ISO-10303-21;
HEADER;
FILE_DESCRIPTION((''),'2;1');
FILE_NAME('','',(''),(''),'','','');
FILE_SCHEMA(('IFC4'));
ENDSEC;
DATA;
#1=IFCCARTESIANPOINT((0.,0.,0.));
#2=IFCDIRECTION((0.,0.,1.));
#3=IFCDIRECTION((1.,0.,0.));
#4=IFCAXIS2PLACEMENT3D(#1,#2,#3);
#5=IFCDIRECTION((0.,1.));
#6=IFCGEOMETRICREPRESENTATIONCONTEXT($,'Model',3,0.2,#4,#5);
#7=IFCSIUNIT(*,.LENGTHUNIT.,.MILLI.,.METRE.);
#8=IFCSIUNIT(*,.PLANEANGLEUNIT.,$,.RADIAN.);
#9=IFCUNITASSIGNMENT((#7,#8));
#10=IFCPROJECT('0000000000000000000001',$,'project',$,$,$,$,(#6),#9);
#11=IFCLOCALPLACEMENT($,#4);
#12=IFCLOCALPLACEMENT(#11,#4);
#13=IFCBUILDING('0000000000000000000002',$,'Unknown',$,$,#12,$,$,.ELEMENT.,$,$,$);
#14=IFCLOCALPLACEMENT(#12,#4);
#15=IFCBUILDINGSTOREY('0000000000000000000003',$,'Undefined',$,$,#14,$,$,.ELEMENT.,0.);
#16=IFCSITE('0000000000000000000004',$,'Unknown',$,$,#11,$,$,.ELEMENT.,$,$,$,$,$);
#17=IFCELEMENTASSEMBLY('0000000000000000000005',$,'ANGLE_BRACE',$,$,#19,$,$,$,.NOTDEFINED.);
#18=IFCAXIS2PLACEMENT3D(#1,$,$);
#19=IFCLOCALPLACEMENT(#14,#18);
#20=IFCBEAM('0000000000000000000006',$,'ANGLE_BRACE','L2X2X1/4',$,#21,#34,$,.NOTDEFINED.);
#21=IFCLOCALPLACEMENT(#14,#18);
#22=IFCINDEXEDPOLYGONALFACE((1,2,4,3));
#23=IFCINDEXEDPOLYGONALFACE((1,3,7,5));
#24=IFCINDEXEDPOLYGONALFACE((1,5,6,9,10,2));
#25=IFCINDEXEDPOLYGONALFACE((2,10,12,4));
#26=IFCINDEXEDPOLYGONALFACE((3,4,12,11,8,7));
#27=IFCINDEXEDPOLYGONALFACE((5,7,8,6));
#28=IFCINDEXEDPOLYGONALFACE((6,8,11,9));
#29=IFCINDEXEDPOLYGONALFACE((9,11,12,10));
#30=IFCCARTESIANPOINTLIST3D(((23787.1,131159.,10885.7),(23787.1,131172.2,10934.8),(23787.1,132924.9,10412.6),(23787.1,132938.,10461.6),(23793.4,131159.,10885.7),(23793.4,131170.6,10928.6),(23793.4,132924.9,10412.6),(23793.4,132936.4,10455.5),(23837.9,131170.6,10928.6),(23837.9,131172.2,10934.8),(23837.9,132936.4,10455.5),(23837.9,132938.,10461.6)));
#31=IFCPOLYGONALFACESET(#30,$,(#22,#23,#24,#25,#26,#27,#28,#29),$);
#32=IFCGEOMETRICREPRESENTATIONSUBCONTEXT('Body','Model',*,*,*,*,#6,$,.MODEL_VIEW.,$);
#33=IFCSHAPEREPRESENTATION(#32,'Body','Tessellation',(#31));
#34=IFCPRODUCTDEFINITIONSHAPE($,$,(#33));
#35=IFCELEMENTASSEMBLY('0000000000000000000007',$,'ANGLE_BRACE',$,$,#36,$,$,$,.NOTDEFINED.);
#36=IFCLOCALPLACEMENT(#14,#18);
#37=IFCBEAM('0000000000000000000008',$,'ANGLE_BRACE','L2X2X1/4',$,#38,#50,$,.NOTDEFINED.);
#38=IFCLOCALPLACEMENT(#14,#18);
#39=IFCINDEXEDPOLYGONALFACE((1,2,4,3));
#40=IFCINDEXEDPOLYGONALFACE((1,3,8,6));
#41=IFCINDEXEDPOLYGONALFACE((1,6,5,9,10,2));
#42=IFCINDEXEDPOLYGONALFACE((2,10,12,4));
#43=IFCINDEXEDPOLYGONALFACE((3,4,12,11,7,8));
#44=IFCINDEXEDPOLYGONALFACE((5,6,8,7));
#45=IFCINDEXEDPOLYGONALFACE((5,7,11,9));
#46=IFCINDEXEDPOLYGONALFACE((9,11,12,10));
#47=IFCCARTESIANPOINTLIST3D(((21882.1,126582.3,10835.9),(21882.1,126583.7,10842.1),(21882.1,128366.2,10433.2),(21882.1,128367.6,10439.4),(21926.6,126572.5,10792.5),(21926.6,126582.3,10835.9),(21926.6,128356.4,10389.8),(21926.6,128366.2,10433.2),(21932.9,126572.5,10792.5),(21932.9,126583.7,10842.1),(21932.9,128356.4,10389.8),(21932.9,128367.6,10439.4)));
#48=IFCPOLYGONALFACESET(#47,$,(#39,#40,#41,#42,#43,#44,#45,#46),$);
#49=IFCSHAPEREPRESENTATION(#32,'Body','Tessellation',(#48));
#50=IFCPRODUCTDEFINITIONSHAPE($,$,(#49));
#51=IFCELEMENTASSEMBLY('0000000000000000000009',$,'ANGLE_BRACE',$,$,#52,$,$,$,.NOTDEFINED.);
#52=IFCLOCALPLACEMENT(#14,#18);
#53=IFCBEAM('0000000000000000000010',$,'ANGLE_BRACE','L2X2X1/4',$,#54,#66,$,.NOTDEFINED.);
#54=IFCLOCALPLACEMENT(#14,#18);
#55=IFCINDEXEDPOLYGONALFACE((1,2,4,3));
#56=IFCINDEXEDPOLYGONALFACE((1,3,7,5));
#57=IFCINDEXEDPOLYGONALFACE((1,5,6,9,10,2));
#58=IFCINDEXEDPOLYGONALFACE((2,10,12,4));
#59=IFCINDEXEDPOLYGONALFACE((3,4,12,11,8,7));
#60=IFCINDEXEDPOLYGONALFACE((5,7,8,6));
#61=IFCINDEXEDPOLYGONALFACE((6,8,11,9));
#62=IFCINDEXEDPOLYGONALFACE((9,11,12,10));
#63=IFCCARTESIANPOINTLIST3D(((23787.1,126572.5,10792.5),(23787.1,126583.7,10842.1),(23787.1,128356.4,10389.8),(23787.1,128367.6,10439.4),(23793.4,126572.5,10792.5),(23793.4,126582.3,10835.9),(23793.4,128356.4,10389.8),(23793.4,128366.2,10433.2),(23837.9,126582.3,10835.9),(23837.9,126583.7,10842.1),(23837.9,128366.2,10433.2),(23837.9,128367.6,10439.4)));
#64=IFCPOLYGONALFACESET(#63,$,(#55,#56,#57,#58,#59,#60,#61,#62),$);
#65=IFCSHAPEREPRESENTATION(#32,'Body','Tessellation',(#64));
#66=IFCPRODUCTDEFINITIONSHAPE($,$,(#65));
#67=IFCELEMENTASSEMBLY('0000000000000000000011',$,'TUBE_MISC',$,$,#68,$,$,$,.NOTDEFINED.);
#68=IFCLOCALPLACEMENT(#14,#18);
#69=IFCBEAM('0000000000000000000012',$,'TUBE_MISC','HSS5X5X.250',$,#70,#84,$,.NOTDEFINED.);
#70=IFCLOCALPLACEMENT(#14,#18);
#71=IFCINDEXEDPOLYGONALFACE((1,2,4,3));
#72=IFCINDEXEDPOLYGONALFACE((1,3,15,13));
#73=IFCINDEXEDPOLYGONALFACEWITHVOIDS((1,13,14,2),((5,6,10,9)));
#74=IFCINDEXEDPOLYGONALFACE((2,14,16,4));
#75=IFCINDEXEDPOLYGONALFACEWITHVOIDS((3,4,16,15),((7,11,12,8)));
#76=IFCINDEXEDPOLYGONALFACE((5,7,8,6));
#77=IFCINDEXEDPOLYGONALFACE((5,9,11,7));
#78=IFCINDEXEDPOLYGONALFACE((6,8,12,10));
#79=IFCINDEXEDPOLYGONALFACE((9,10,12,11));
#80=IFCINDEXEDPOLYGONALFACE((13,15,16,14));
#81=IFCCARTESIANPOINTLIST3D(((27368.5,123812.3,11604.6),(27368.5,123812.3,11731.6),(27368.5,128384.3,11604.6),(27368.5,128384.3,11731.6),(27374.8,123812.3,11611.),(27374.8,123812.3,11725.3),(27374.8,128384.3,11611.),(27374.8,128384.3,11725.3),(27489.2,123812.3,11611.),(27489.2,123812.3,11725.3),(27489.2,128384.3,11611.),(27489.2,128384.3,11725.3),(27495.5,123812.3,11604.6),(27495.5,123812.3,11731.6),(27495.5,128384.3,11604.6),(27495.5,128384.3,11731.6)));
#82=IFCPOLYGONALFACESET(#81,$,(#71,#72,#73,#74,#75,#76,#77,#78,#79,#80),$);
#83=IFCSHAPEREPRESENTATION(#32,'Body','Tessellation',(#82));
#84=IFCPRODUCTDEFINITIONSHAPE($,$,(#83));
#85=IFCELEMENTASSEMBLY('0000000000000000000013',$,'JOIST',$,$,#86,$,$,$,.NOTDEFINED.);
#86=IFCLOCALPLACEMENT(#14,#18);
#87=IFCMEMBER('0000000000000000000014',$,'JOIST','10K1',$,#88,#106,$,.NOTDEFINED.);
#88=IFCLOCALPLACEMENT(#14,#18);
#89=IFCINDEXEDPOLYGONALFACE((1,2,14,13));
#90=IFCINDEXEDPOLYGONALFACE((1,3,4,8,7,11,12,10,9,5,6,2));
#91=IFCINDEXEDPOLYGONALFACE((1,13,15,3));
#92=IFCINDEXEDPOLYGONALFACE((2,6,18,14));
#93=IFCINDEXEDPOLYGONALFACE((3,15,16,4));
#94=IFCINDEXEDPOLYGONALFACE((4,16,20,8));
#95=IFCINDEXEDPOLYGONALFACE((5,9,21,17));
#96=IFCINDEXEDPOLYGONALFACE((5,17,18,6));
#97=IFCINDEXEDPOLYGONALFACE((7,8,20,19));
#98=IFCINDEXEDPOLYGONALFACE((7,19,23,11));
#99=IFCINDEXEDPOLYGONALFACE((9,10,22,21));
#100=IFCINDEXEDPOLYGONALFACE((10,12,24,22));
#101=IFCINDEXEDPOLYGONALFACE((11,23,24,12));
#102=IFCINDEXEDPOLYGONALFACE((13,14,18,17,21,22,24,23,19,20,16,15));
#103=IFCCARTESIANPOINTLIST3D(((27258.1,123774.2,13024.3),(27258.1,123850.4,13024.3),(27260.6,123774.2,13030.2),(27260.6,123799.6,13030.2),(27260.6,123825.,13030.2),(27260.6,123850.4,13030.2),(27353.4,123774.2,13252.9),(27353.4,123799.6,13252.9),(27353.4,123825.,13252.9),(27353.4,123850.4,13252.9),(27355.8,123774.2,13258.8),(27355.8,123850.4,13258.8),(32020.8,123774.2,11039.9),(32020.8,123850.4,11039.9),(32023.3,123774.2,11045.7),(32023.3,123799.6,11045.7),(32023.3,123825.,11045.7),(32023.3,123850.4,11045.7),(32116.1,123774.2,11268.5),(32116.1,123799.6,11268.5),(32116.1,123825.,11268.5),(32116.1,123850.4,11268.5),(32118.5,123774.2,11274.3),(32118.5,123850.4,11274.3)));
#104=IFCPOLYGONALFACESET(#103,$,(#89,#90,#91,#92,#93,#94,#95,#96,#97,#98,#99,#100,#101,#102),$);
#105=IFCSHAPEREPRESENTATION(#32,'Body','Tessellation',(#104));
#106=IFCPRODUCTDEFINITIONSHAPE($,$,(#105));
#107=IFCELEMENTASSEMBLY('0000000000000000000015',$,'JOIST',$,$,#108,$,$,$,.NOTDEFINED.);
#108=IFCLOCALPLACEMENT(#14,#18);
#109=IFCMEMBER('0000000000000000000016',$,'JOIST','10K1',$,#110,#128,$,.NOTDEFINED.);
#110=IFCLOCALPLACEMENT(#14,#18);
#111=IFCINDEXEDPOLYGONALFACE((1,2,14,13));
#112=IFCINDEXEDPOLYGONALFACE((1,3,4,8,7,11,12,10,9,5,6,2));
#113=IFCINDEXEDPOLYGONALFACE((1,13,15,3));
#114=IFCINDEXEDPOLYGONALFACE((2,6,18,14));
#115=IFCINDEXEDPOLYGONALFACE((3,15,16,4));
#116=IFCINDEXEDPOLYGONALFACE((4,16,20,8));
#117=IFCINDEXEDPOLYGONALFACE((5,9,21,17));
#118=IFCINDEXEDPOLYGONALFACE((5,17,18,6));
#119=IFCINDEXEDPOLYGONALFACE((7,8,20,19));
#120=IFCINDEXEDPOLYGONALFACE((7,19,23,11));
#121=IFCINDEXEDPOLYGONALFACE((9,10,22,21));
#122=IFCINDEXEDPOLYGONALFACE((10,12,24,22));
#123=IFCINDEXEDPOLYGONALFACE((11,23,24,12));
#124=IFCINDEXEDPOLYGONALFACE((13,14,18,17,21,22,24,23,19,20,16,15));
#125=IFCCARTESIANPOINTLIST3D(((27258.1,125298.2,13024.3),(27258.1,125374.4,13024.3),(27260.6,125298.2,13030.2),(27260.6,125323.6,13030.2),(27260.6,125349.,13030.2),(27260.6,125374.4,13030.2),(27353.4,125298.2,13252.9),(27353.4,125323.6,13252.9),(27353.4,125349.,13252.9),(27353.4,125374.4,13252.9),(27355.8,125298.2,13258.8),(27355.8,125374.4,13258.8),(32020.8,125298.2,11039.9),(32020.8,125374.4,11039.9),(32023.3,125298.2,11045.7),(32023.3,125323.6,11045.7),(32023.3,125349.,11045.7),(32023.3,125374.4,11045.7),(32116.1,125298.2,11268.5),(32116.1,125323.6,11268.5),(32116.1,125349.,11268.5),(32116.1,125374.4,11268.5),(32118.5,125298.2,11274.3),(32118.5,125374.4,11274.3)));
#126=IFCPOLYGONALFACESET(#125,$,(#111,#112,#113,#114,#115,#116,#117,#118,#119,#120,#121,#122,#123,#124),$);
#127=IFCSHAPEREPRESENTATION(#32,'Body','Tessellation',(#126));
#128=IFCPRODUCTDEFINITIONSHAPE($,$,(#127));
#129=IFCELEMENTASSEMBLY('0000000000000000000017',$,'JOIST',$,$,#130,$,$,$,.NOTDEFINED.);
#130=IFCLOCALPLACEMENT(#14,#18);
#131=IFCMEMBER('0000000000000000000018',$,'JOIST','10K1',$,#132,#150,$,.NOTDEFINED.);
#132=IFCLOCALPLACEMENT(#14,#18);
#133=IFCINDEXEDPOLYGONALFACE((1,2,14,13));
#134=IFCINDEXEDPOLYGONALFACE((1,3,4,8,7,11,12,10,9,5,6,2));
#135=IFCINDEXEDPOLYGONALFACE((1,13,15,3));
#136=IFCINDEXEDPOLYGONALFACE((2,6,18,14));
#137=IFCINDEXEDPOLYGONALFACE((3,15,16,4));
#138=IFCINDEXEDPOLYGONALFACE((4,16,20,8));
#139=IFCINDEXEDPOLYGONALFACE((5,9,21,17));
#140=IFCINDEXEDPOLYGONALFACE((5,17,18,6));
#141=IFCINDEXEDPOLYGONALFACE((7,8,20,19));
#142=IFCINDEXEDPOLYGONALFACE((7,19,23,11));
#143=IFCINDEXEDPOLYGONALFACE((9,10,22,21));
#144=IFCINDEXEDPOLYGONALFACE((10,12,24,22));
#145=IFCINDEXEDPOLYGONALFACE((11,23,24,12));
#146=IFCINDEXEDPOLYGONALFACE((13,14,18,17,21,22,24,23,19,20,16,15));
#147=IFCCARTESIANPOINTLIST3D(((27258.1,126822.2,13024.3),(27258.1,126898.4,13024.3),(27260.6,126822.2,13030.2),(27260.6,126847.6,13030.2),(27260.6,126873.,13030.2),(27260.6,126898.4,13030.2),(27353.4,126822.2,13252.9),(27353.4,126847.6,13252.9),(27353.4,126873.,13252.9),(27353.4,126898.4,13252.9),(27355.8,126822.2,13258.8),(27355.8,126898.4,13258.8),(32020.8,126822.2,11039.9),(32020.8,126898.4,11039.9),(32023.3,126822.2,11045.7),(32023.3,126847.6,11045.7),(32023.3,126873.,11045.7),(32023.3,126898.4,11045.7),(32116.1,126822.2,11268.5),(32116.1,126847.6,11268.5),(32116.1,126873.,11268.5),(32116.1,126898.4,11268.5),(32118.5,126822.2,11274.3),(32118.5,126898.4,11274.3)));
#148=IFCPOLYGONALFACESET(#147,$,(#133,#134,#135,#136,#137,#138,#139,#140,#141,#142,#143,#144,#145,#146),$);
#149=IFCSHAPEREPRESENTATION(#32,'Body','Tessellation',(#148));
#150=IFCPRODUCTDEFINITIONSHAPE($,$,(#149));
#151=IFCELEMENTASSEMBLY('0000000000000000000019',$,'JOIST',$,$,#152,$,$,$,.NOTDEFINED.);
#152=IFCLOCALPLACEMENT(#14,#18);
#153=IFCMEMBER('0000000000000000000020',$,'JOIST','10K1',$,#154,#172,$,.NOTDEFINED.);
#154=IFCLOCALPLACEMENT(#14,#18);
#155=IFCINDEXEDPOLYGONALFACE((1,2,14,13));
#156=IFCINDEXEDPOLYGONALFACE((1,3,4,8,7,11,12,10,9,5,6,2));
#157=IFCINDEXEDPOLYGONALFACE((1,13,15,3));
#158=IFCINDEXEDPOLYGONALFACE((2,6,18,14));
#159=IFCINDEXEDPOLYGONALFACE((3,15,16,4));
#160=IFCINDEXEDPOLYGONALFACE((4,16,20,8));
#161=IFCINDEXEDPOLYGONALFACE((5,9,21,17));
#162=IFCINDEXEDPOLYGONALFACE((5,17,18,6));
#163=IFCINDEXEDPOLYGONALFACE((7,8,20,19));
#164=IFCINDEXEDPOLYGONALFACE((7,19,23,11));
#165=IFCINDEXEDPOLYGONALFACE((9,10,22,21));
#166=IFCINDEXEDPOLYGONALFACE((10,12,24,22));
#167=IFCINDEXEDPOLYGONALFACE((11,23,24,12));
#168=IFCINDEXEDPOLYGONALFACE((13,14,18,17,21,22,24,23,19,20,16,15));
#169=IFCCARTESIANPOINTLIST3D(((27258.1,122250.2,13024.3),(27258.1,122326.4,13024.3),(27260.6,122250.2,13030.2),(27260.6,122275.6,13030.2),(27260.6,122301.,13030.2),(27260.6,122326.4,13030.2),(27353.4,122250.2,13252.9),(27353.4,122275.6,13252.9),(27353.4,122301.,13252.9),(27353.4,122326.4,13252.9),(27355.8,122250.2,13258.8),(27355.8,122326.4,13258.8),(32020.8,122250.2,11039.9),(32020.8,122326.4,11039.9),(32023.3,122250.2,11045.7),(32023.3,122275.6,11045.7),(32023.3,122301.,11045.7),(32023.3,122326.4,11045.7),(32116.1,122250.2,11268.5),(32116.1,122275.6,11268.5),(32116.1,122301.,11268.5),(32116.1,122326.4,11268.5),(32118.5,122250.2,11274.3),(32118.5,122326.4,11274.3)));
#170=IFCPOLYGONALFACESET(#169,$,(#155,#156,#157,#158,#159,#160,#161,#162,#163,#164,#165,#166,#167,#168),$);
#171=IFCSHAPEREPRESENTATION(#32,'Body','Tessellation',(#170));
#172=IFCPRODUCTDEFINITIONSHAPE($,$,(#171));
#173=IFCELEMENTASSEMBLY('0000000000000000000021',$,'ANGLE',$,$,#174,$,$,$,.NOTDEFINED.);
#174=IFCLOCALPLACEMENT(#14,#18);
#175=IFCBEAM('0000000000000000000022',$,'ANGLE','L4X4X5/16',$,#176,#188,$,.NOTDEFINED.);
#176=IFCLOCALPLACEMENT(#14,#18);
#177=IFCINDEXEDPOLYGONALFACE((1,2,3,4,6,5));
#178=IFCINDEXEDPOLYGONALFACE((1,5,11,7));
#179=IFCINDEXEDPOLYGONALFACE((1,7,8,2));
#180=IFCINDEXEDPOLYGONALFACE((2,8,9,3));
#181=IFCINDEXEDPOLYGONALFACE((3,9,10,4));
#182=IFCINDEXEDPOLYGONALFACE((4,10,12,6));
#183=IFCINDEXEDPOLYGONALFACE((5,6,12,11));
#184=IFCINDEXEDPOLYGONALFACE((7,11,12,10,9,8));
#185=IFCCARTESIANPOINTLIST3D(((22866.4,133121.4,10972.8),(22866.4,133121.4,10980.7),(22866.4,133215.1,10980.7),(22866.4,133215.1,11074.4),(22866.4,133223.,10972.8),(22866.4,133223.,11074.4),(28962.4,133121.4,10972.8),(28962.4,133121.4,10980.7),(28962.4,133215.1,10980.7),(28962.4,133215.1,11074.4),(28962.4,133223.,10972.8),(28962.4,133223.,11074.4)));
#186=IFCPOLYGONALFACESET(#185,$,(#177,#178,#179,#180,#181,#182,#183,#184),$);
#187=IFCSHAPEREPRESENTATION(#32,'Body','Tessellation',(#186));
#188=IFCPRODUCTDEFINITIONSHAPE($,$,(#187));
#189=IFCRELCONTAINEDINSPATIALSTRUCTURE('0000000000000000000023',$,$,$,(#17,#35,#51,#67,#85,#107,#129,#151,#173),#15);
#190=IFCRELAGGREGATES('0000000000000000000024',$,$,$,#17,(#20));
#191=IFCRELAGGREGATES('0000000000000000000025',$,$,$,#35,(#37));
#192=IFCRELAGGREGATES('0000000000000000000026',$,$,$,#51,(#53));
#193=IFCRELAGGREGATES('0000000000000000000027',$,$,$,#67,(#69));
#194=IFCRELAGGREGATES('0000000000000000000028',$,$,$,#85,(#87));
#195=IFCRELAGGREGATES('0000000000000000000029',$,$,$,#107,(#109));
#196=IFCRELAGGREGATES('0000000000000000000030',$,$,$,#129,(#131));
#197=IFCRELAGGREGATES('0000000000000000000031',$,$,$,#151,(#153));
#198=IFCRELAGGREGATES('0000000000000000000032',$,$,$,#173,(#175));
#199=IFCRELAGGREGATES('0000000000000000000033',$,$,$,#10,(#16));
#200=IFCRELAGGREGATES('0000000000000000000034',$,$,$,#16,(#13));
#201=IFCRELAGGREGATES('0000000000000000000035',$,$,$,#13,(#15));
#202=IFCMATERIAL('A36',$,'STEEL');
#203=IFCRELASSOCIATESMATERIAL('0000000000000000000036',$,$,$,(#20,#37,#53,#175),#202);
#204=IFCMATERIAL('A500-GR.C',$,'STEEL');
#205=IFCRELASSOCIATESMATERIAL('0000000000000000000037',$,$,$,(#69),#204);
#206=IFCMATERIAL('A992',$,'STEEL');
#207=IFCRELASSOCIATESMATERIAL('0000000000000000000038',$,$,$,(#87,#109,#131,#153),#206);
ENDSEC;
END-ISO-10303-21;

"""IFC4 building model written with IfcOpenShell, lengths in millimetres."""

from ifc_helpers import new_model, si_unit, direction, frame, origin_with_axes, place, context, subcontext, project, spatial, line, indexed_curve, outline, extrude, material, element, aggregate, save


model = new_model("IFC4")

# Units and contexts
model_context = context("Model", 3, precision=0.2, world=origin_with_axes(), true_north=direction((0.0, 1.0)))
body_context = subcontext(model_context, "Body", "Model", "MODEL_VIEW")
ifc_project = project(units=[si_unit("LENGTHUNIT", "METRE", prefix="MILLI"), si_unit("PLANEANGLEUNIT", "RADIAN")], contexts=[model_context])

# Site, building, storey
site_placement = place(None, origin_with_axes())
site = spatial("IfcSite", under=ifc_project, at=site_placement, Name="Unknown", CompositionType="ELEMENT")
building_placement = place(site_placement, origin_with_axes())
building = spatial("IfcBuilding", under=site, at=building_placement, Name="Unknown", CompositionType="ELEMENT")
storey_placement = place(building_placement, origin_with_axes())
storey = spatial("IfcBuildingStorey", under=building, at=storey_placement, Name="Undefined", CompositionType="ELEMENT", Elevation=0.0)

# Shared definitions
ifc_material_1 = material(Name="A500-GR.C", Category="STEEL")

# Element assemblies, beams
ifc_material_2 = material(Name="A992", Category="STEEL")
ifc_material_3 = material(Name="A36", Category="STEEL")
assembly_1_placement = place(storey_placement, frame((23812.5, 131165.6, 10910.2), z_axis=(0.0, -0.258819, -0.965926), x_axis=(0.0, 0.965926, -0.258819)))
assembly_1 = element("IfcElementAssembly", 1, at=assembly_1_placement, inside=storey, Name="ANGLE_BRACE", PredefinedType="NOTDEFINED")
beam_1_placement = place(assembly_1_placement, origin_with_axes())
beam_1 = element("IfcBeam", 2, at=beam_1_placement, material=ifc_material_3, Name="ANGLE_BRACE", Description="L2X2X1/4", PredefinedType="NOTDEFINED", context=body_context, shape_type="SolidModel", body=[
    extrude(outline(indexed_curve([(-25.4, -25.4), (25.4, -25.4), (25.4, -19.1), (-19.1, -19.1), (-19.1, 25.4), (-25.4, 25.4)], segments=[line(1, 2, 3, 4, 5, 6, 1)])), frame((0.0, 0.0, 0.0), z_axis=(-1.0, 0.0, 0.0), x_axis=(0.0, 0.0, 1.0)), (0.0, 0.0, -1.0), 1828.1),
])
aggregate(assembly_1, [beam_1])
assembly_2_placement = place(storey_placement, frame((21907.5, 126578.1, 10817.3), z_axis=(-1.0, 0.0, 0.0), x_axis=(0.0, 0.97546, -0.220178)))
assembly_2 = element("IfcElementAssembly", 3, at=assembly_2_placement, inside=storey, Name="ANGLE_BRACE", PredefinedType="NOTDEFINED")
beam_2_placement = place(assembly_2_placement, origin_with_axes())
beam_2 = element("IfcBeam", 4, at=beam_2_placement, material=ifc_material_3, Name="ANGLE_BRACE", Description="L2X2X1/4", PredefinedType="NOTDEFINED", context=body_context, shape_type="SolidModel", body=[
    extrude(outline(indexed_curve([(-25.4, -25.4), (25.4, -25.4), (25.4, -19.1), (-19.1, -19.1), (-19.1, 25.4), (-25.4, 25.4)], segments=[line(1, 2, 3, 4, 5, 6, 1)])), frame((0.0, 0.0, 0.0), z_axis=(-1.0, 0.0, 0.0), x_axis=(0.0, 0.0, 1.0)), (0.0, 0.0, -1.0), 1828.8),
])
aggregate(assembly_2, [beam_2])
assembly_3_placement = place(storey_placement, frame((23812.5, 126578.1, 10817.3), z_axis=(0.0, -0.220178, -0.97546), x_axis=(0.0, 0.97546, -0.220178)))
assembly_3 = element("IfcElementAssembly", 5, at=assembly_3_placement, inside=storey, Name="ANGLE_BRACE", PredefinedType="NOTDEFINED")
beam_3_placement = place(assembly_3_placement, origin_with_axes())
beam_3 = element("IfcBeam", 6, at=beam_3_placement, material=ifc_material_3, Name="ANGLE_BRACE", Description="L2X2X1/4", PredefinedType="NOTDEFINED", context=body_context, shape_type="SolidModel", body=[
    extrude(outline(indexed_curve([(-25.4, -25.4), (25.4, -25.4), (25.4, -19.1), (-19.1, -19.1), (-19.1, 25.4), (-25.4, 25.4)], segments=[line(1, 2, 3, 4, 5, 6, 1)])), frame((0.0, 0.0, 0.0), z_axis=(-1.0, 0.0, 0.0), x_axis=(0.0, 0.0, 1.0)), (0.0, 0.0, -1.0), 1828.8),
])
aggregate(assembly_3, [beam_3])
assembly_4_placement = place(storey_placement, frame((27432.0, 123812.3, 11668.1), z_axis=(1.0, 0.0, 0.0), x_axis=(0.0, 1.0, 0.0)))
assembly_4 = element("IfcElementAssembly", 7, at=assembly_4_placement, inside=storey, Name="TUBE_MISC", PredefinedType="NOTDEFINED")
beam_4_placement = place(assembly_4_placement, origin_with_axes())
beam_4 = element("IfcBeam", 8, at=beam_4_placement, material=ifc_material_1, Name="TUBE_MISC", Description="HSS5X5X.250", PredefinedType="NOTDEFINED", context=body_context, shape_type="SolidModel", body=[
    extrude(outline(indexed_curve([(-63.5, -63.5), (63.5, -63.5), (63.5, 63.5), (-63.5, 63.5)], segments=[line(1, 2, 3, 4, 1)]), holes=[indexed_curve([(-57.1, -57.1), (-57.1, 57.1), (57.1, 57.1), (57.1, -57.1)], segments=[line(1, 2, 3, 4, 1)])]), frame((0.0, 0.0, 0.0), z_axis=(-1.0, 0.0, 0.0), x_axis=(0.0, 0.0, 1.0)), (0.0, 0.0, -1.0), 4572.0),
])
aggregate(assembly_4, [beam_4])

# Element assemblies, members
assembly_5_placement = place(storey_placement, frame((27307.0, 123812.3, 13141.6), z_axis=(0.0, -1.0, 0.0), x_axis=(0.923077, 0.000001, -0.384615)))
assembly_5 = element("IfcElementAssembly", 9, at=assembly_5_placement, inside=storey, Name="JOIST", PredefinedType="NOTDEFINED")
member_1_placement = place(assembly_5_placement, origin_with_axes())
member_1 = element("IfcMember", 10, at=member_1_placement, material=ifc_material_2, Name="JOIST", Description="10K1", PredefinedType="NOTDEFINED", context=body_context, shape_type="SolidModel", body=[
    extrude(outline(indexed_curve([(-38.1, -127.0), (38.1, -127.0), (38.1, -120.7), (12.7, -120.7), (12.7, 120.7), (38.1, 120.7), (38.1, 127.0), (-38.1, 127.0), (-38.1, 120.7), (-12.7, 120.7), (-12.7, -120.7), (-38.1, -120.7)], segments=[line(1, 2, 3, 4, 5, 6, 7, 8, 9, 10, 11, 12, 1)])), frame((0.0, 0.0, 0.0), z_axis=(-1.0, 0.0, 0.0), x_axis=(0.0, 0.0, 1.0)), (0.0, 0.0, -1.0), 5159.6),
])
aggregate(assembly_5, [member_1])
assembly_6_placement = place(storey_placement, frame((27307.0, 125336.3, 13141.6), z_axis=(0.0, -1.0, 0.0), x_axis=(0.923077, 0.000001, -0.384615)))
assembly_6 = element("IfcElementAssembly", 11, at=assembly_6_placement, inside=storey, Name="JOIST", PredefinedType="NOTDEFINED")
member_2_placement = place(assembly_6_placement, origin_with_axes())
member_2 = element("IfcMember", 12, at=member_2_placement, material=ifc_material_2, Name="JOIST", Description="10K1", PredefinedType="NOTDEFINED", context=body_context, shape_type="SolidModel", body=[
    extrude(outline(indexed_curve([(-38.1, -127.0), (38.1, -127.0), (38.1, -120.7), (12.7, -120.7), (12.7, 120.7), (38.1, 120.7), (38.1, 127.0), (-38.1, 127.0), (-38.1, 120.7), (-12.7, 120.7), (-12.7, -120.7), (-38.1, -120.7)], segments=[line(1, 2, 3, 4, 5, 6, 7, 8, 9, 10, 11, 12, 1)])), frame((0.0, 0.0, 0.0), z_axis=(-1.0, 0.0, 0.0), x_axis=(0.0, 0.0, 1.0)), (0.0, 0.0, -1.0), 5159.6),
])
aggregate(assembly_6, [member_2])
assembly_7_placement = place(storey_placement, frame((27307.0, 126860.3, 13141.6), z_axis=(0.0, -1.0, 0.0), x_axis=(0.923077, 0.000001, -0.384615)))
assembly_7 = element("IfcElementAssembly", 13, at=assembly_7_placement, inside=storey, Name="JOIST", PredefinedType="NOTDEFINED")
member_3_placement = place(assembly_7_placement, origin_with_axes())
member_3 = element("IfcMember", 14, at=member_3_placement, material=ifc_material_2, Name="JOIST", Description="10K1", PredefinedType="NOTDEFINED", context=body_context, shape_type="SolidModel", body=[
    extrude(outline(indexed_curve([(-38.1, -127.0), (38.1, -127.0), (38.1, -120.7), (12.7, -120.7), (12.7, 120.7), (38.1, 120.7), (38.1, 127.0), (-38.1, 127.0), (-38.1, 120.7), (-12.7, 120.7), (-12.7, -120.7), (-38.1, -120.7)], segments=[line(1, 2, 3, 4, 5, 6, 7, 8, 9, 10, 11, 12, 1)])), frame((0.0, 0.0, 0.0), z_axis=(-1.0, 0.0, 0.0), x_axis=(0.0, 0.0, 1.0)), (0.0, 0.0, -1.0), 5159.6),
])
aggregate(assembly_7, [member_3])
assembly_8_placement = place(storey_placement, frame((27307.0, 122288.3, 13141.6), z_axis=(0.0, -1.0, 0.0), x_axis=(0.923077, 0.000001, -0.384615)))
assembly_8 = element("IfcElementAssembly", 15, at=assembly_8_placement, inside=storey, Name="JOIST", PredefinedType="NOTDEFINED")
member_4_placement = place(assembly_8_placement, origin_with_axes())
member_4 = element("IfcMember", 16, at=member_4_placement, material=ifc_material_2, Name="JOIST", Description="10K1", PredefinedType="NOTDEFINED", context=body_context, shape_type="SolidModel", body=[
    extrude(outline(indexed_curve([(-38.1, -127.0), (38.1, -127.0), (38.1, -120.7), (12.7, -120.7), (12.7, 120.7), (38.1, 120.7), (38.1, 127.0), (-38.1, 127.0), (-38.1, 120.7), (-12.7, 120.7), (-12.7, -120.7), (-38.1, -120.7)], segments=[line(1, 2, 3, 4, 5, 6, 7, 8, 9, 10, 11, 12, 1)])), frame((0.0, 0.0, 0.0), z_axis=(-1.0, 0.0, 0.0), x_axis=(0.0, 0.0, 1.0)), (0.0, 0.0, -1.0), 5159.6),
])
aggregate(assembly_8, [member_4])

# Element assembly, beam
assembly_9_placement = place(storey_placement, frame((22866.3, 133172.2, 11023.6), z_axis=(0.0, -1.0, 0.0), x_axis=(1.0, 0.0, 0.0)))
assembly_9 = element("IfcElementAssembly", 17, at=assembly_9_placement, inside=storey, Name="ANGLE", PredefinedType="NOTDEFINED")
beam_5_placement = place(assembly_9_placement, origin_with_axes())
beam_5 = element("IfcBeam", 18, at=beam_5_placement, material=ifc_material_3, Name="ANGLE", Description="L4X4X5/16", PredefinedType="NOTDEFINED", context=body_context, shape_type="SolidModel", body=[
    extrude(outline(indexed_curve([(-50.8, -50.8), (50.8, -50.8), (50.8, -42.9), (-42.9, -42.9), (-42.9, 50.8), (-50.8, 50.8)], segments=[line(1, 2, 3, 4, 5, 6, 1)])), frame((0.0, 0.0, 0.0), z_axis=(-1.0, 0.0, 0.0), x_axis=(0.0, 0.0, 1.0)), (0.0, 0.0, -1.0), 6096.0),
])
aggregate(assembly_9, [beam_5])

save(model, "model.ifc")
